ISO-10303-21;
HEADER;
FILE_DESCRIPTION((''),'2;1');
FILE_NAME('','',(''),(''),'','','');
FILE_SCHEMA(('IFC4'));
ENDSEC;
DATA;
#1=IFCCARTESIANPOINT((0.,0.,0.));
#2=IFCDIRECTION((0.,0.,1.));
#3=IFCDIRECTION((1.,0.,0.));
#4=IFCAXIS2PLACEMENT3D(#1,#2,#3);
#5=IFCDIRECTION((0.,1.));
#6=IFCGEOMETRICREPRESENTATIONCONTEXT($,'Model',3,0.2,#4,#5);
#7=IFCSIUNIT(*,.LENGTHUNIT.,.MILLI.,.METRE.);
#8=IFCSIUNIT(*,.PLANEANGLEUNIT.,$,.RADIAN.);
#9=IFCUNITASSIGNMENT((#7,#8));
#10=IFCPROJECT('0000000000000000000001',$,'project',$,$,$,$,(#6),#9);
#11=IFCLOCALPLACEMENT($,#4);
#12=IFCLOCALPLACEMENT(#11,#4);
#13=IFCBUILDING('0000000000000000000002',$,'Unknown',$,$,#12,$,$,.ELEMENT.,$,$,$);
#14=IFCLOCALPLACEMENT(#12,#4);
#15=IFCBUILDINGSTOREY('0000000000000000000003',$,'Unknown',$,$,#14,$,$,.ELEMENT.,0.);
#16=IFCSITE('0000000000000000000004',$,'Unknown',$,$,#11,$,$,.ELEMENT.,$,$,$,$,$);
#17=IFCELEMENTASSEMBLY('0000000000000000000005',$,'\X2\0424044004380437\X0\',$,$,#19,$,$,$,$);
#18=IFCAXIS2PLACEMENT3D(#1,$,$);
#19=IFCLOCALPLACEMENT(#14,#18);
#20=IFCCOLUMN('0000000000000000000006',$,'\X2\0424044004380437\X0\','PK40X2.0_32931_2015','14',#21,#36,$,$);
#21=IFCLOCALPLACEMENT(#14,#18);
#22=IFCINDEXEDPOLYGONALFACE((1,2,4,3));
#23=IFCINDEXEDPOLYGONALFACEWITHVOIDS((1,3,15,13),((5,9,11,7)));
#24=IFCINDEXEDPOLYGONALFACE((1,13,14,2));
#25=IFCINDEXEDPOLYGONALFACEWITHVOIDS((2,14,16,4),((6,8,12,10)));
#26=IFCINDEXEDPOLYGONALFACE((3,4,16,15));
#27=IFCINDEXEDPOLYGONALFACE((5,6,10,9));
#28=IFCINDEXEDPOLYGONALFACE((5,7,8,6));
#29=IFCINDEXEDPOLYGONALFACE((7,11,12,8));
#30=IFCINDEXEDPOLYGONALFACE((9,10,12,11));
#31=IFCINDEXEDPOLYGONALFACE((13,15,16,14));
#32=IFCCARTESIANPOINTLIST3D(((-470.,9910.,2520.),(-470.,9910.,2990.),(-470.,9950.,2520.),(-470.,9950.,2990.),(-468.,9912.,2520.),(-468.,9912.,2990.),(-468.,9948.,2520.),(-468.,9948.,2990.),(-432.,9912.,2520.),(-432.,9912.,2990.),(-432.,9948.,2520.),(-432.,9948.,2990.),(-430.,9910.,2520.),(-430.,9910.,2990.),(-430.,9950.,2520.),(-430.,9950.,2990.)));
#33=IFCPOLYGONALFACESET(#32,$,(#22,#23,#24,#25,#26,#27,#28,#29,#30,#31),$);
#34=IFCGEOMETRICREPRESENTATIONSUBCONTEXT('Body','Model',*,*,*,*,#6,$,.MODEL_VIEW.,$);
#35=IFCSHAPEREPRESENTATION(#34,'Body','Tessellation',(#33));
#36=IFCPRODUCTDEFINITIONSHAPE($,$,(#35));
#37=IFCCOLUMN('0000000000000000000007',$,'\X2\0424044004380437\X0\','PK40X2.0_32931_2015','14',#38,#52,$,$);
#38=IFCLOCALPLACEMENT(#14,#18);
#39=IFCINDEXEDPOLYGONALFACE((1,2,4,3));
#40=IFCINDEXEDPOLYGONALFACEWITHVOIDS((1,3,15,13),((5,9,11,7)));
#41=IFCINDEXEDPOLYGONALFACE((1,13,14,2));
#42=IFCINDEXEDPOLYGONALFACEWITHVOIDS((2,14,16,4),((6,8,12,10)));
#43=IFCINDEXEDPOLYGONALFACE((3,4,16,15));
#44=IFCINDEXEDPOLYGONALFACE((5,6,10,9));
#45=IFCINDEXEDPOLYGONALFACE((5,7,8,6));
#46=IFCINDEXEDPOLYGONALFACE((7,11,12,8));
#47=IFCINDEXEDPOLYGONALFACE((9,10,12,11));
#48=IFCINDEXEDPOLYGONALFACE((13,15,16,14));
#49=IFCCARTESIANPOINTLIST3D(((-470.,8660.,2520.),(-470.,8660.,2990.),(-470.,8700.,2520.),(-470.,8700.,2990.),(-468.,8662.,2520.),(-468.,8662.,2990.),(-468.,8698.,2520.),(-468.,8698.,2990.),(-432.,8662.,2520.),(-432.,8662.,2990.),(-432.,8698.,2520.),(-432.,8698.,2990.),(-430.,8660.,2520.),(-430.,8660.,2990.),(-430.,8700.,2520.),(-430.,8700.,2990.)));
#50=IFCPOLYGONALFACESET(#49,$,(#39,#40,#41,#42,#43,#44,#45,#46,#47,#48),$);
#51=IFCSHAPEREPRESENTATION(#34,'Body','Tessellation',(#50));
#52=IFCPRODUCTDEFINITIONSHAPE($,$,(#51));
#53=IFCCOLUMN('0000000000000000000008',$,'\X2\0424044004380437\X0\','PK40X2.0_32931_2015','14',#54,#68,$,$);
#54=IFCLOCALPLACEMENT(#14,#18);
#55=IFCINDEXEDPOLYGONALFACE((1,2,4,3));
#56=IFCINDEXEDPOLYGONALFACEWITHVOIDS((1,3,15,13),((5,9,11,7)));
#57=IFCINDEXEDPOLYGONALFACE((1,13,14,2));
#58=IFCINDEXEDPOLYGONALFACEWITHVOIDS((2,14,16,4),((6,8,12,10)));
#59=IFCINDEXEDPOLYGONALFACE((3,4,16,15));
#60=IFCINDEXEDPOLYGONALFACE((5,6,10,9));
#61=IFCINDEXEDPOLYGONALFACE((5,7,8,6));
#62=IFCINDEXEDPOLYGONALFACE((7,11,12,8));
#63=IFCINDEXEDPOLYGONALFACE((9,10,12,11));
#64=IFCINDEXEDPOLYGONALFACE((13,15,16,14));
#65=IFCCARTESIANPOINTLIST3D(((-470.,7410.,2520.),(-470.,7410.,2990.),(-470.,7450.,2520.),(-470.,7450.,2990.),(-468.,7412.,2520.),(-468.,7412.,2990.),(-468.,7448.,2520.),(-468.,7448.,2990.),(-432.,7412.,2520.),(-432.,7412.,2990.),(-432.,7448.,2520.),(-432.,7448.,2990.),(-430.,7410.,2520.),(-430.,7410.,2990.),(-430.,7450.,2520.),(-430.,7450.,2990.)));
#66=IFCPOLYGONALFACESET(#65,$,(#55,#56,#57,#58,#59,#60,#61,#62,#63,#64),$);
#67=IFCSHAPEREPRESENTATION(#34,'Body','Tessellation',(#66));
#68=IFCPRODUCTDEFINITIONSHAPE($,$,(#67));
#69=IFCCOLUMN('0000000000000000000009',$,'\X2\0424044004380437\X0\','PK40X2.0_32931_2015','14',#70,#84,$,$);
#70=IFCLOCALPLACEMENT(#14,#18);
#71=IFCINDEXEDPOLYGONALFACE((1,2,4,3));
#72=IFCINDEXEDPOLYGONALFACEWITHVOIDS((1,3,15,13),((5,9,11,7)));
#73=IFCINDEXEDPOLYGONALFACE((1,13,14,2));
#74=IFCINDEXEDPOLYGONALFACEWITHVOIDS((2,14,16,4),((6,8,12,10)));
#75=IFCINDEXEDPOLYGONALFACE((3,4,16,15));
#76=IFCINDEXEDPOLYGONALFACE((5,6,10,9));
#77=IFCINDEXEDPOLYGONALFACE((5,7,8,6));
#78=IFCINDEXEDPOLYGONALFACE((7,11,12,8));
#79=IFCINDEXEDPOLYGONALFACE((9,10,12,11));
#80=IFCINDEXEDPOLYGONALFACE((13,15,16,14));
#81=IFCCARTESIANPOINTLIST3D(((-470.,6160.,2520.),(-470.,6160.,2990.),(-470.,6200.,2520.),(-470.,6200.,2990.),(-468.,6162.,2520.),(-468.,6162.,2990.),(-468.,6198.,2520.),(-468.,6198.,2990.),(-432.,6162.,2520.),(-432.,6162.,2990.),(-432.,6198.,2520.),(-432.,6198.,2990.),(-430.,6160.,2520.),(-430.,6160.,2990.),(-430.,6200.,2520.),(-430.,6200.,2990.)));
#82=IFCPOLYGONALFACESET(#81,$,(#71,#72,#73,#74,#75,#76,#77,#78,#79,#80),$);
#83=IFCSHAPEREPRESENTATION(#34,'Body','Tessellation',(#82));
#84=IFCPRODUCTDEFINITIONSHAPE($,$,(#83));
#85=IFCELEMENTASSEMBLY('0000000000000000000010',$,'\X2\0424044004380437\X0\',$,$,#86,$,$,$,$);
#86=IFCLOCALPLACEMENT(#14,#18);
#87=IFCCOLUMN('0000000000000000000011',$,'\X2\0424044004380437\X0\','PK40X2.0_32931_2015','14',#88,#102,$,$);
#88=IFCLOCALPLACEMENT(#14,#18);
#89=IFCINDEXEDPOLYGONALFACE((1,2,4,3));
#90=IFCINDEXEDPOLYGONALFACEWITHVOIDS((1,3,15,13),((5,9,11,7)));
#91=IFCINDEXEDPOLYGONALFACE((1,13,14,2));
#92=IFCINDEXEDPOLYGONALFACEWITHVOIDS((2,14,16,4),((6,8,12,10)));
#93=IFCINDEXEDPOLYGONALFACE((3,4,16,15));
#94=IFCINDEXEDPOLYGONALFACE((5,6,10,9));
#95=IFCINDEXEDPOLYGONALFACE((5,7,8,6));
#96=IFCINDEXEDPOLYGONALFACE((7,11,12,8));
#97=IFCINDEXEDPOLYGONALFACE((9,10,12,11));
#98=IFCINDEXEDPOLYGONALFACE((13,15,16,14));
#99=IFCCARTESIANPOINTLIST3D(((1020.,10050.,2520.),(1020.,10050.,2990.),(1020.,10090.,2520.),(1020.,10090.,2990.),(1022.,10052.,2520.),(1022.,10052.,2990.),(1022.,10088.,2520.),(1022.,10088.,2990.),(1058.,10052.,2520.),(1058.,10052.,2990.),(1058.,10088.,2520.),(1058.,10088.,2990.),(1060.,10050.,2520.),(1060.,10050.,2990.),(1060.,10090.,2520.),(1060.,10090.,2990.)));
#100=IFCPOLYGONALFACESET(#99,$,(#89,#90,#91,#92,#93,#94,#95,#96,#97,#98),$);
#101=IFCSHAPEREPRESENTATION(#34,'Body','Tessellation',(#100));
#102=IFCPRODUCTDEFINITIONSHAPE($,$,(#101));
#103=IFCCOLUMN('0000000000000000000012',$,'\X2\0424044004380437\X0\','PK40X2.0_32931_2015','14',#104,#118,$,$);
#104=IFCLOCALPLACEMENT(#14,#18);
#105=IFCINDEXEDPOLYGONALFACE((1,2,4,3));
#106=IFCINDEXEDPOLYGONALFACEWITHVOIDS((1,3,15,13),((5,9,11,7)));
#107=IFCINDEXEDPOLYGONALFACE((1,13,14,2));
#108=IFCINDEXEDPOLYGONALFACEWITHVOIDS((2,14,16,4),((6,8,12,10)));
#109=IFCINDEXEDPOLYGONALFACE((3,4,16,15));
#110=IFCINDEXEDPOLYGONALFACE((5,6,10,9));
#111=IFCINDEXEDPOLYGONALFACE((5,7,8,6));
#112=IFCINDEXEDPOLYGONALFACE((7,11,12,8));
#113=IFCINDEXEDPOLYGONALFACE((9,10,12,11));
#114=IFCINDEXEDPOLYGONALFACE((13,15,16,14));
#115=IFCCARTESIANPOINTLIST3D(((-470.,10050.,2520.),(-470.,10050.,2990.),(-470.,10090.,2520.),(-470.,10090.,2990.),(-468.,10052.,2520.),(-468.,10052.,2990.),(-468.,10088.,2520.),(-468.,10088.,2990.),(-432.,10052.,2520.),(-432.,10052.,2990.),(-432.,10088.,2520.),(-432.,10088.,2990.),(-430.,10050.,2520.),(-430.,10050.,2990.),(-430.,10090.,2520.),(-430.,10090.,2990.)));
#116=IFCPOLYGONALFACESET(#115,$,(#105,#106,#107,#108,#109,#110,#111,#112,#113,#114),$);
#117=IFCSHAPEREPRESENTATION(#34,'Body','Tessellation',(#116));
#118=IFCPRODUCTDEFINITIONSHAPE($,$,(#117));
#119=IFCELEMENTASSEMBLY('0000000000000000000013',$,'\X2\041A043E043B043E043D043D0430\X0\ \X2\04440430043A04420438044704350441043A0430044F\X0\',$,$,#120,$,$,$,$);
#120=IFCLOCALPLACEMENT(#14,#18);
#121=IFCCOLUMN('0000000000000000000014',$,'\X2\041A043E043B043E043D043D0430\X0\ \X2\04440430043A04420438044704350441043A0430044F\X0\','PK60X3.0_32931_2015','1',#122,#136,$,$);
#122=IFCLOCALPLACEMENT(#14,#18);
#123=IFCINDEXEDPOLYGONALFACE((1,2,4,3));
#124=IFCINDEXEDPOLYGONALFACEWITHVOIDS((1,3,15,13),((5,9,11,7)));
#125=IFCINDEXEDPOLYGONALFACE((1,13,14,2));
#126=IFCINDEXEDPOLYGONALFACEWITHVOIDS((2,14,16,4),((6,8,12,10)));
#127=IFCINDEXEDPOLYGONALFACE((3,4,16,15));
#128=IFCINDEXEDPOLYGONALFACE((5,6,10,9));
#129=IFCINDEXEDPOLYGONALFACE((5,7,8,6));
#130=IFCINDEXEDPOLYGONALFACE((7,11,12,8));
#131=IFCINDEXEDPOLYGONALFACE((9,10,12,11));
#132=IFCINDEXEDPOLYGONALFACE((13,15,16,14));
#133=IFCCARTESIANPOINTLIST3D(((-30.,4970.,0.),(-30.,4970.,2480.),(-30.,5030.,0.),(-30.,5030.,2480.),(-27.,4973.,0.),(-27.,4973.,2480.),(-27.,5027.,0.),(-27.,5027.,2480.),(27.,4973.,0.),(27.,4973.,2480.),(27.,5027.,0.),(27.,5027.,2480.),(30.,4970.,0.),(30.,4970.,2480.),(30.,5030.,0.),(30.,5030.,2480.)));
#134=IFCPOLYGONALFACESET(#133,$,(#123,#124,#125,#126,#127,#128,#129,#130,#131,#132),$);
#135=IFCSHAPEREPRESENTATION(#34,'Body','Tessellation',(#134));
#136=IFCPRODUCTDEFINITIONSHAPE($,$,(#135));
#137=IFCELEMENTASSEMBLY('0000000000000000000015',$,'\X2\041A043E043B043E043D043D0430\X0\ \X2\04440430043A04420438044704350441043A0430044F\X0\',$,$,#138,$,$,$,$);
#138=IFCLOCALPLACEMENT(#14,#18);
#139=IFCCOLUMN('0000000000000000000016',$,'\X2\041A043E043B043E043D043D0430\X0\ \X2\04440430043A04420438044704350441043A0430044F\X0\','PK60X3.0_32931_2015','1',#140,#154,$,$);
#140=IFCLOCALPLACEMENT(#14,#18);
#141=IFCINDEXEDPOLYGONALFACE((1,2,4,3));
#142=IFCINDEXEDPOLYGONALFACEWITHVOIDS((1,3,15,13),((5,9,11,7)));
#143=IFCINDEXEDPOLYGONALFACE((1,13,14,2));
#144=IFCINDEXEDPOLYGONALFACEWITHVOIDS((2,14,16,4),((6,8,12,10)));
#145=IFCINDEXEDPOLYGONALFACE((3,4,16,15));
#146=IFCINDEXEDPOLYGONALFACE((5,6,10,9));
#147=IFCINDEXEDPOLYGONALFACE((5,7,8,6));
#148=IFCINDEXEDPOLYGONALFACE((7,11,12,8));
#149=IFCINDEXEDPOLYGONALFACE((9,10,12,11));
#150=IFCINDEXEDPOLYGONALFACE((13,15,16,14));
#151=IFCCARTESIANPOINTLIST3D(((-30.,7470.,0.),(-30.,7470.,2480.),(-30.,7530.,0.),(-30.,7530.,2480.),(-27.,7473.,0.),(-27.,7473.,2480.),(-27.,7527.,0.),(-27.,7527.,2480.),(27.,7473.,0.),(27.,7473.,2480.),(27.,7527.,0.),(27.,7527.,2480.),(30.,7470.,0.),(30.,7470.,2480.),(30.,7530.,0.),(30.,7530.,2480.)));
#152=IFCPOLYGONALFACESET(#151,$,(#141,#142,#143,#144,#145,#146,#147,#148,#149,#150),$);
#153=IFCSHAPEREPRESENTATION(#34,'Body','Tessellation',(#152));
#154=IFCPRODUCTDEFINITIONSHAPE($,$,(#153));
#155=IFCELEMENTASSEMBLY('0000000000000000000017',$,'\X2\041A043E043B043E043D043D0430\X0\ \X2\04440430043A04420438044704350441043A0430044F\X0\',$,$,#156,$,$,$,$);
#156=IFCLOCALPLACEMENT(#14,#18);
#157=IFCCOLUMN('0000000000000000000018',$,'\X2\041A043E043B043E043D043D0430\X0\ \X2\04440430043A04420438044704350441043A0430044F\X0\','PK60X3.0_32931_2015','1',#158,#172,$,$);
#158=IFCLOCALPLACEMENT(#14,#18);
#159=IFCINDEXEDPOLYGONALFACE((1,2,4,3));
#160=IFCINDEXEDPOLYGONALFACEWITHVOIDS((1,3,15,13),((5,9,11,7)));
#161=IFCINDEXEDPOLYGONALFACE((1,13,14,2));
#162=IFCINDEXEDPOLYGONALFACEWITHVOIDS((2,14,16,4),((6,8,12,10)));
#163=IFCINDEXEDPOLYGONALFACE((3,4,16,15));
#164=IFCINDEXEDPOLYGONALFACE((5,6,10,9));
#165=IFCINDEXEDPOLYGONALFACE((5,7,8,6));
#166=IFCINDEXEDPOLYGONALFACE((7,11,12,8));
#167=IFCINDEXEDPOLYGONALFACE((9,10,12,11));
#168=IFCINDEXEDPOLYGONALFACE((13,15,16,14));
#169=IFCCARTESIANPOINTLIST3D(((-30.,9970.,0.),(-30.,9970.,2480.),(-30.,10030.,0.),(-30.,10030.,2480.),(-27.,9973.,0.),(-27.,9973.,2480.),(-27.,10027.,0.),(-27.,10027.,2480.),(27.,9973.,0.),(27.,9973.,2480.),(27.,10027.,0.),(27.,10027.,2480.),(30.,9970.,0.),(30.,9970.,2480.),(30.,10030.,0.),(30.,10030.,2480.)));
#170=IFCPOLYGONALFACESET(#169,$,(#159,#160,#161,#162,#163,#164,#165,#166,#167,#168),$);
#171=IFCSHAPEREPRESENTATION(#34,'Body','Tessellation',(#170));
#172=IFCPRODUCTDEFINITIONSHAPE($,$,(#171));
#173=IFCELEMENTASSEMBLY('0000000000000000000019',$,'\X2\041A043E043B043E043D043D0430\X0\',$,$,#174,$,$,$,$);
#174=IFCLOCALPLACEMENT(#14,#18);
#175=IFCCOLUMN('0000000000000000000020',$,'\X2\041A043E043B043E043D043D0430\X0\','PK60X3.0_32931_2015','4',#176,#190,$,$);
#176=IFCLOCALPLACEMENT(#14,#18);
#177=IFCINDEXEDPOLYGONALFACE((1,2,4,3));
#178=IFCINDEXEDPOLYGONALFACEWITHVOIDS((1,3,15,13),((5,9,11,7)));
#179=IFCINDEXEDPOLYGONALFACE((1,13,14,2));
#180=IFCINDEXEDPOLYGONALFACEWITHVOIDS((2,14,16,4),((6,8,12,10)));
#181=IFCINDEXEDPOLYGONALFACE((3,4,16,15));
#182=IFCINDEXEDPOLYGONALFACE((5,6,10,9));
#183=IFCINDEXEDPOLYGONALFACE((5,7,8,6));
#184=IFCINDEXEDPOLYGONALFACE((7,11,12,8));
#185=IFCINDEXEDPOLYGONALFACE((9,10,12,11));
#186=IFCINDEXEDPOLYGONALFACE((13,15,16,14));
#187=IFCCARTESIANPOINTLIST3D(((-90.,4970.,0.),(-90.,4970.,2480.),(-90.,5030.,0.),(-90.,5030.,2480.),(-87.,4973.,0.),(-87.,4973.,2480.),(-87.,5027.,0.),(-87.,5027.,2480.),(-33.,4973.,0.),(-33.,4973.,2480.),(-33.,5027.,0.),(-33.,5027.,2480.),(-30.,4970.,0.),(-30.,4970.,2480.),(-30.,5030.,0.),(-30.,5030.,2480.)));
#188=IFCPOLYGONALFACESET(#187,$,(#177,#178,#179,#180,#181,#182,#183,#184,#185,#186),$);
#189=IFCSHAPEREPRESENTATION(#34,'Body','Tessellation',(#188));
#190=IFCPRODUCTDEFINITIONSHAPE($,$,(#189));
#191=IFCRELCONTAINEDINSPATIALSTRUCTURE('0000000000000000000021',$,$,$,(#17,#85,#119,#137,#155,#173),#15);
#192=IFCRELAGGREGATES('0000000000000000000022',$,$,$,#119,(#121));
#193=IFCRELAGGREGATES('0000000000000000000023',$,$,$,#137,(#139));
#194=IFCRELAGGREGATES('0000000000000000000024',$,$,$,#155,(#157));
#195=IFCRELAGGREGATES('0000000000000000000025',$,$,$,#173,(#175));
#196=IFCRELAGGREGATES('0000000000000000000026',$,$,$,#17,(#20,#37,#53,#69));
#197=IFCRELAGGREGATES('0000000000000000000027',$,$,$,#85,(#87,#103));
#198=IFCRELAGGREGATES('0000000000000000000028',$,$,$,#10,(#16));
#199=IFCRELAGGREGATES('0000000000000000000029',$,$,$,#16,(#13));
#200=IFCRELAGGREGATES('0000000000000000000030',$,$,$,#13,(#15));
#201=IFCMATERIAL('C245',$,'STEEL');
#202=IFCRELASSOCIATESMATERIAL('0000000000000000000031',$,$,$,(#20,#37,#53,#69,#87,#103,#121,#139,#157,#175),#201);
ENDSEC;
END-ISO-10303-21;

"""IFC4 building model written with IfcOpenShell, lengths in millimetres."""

from ifc_helpers import new_model, si_unit, direction, frame, origin_with_axes, place, context, subcontext, project, spatial, line, indexed_curve, outline, extrude, material, element, aggregate, save


model = new_model("IFC4")

# Units and contexts
model_context = context("Model", 3, precision=0.2, world=origin_with_axes(), true_north=direction((0.0, 1.0)))
body_context = subcontext(model_context, "Body", "Model", "MODEL_VIEW")
ifc_project = project(units=[si_unit("LENGTHUNIT", "METRE", prefix="MILLI"), si_unit("PLANEANGLEUNIT", "RADIAN")], contexts=[model_context])

# Site, building, storey
site_placement = place(None, origin_with_axes())
site = spatial("IfcSite", under=ifc_project, at=site_placement, Name="Unknown", CompositionType="ELEMENT")
building_placement = place(site_placement, origin_with_axes())
building = spatial("IfcBuilding", under=site, at=building_placement, Name="Unknown", CompositionType="ELEMENT")
storey_placement = place(building_placement, origin_with_axes())
storey = spatial("IfcBuildingStorey", under=building, at=storey_placement, Name="Unknown", CompositionType="ELEMENT", Elevation=0.0)

# Element assemblies, columns
assembly_1_placement = place(storey_placement, frame((-450.0, -500.0, 3010.0), z_axis=(1.0, 0.0, 0.0), x_axis=(0.0, 1.0, 0.0)))
assembly_1 = element("IfcElementAssembly", 1, at=assembly_1_placement, inside=storey, Name="Фриз")
ifc_material = material(Name="C245", Category="STEEL")
column_1_placement = place(assembly_1_placement, frame((10430.0, -490.0, 0.0), z_axis=(1.0, 0.0, 0.0), x_axis=(0.0, 1.0, 0.0)))
column_1 = element("IfcColumn", 2, at=column_1_placement, material=ifc_material, Name="Фриз", Description="PK40X2.0_32931_2015", ObjectType="14", context=body_context, shape_type="SolidModel", body=[
    extrude(outline(indexed_curve([(-20.0, -20.0), (20.0, -20.0), (20.0, 20.0), (-20.0, 20.0)], segments=[line(1, 2, 3, 4, 1)]), holes=[indexed_curve([(-18.0, -18.0), (-18.0, 18.0), (18.0, 18.0), (18.0, -18.0)], segments=[line(1, 2, 3, 4, 1)])]), frame((0.0, 0.0, 0.0), z_axis=(-1.0, 0.0, 0.0), x_axis=(0.0, 0.0, 1.0)), (0.0, 0.0, -1.0), 470.0),
])
column_2_placement = place(assembly_1_placement, frame((9180.0, -490.0, 0.0), z_axis=(1.0, 0.0, 0.0), x_axis=(0.0, 1.0, 0.0)))
column_2 = element("IfcColumn", 3, at=column_2_placement, material=ifc_material, Name="Фриз", Description="PK40X2.0_32931_2015", ObjectType="14", context=body_context, shape_type="SolidModel", body=[
    extrude(outline(indexed_curve([(-20.0, -20.0), (20.0, -20.0), (20.0, 20.0), (-20.0, 20.0)], segments=[line(1, 2, 3, 4, 1)]), holes=[indexed_curve([(-18.0, -18.0), (-18.0, 18.0), (18.0, 18.0), (18.0, -18.0)], segments=[line(1, 2, 3, 4, 1)])]), frame((0.0, 0.0, 0.0), z_axis=(-1.0, 0.0, 0.0), x_axis=(0.0, 0.0, 1.0)), (0.0, 0.0, -1.0), 470.0),
])
column_3_placement = place(assembly_1_placement, frame((7930.0, -490.0, 0.0), z_axis=(1.0, 0.0, 0.0), x_axis=(0.0, 1.0, 0.0)))
column_3 = element("IfcColumn", 4, at=column_3_placement, material=ifc_material, Name="Фриз", Description="PK40X2.0_32931_2015", ObjectType="14", context=body_context, shape_type="SolidModel", body=[
    extrude(outline(indexed_curve([(-20.0, -20.0), (20.0, -20.0), (20.0, 20.0), (-20.0, 20.0)], segments=[line(1, 2, 3, 4, 1)]), holes=[indexed_curve([(-18.0, -18.0), (-18.0, 18.0), (18.0, 18.0), (18.0, -18.0)], segments=[line(1, 2, 3, 4, 1)])]), frame((0.0, 0.0, 0.0), z_axis=(-1.0, 0.0, 0.0), x_axis=(0.0, 0.0, 1.0)), (0.0, 0.0, -1.0), 470.0),
])
column_4_placement = place(assembly_1_placement, frame((6680.0, -490.0, 0.0), z_axis=(1.0, 0.0, 0.0), x_axis=(0.0, 1.0, 0.0)))
column_4 = element("IfcColumn", 5, at=column_4_placement, material=ifc_material, Name="Фриз", Description="PK40X2.0_32931_2015", ObjectType="14", context=body_context, shape_type="SolidModel", body=[
    extrude(outline(indexed_curve([(-20.0, -20.0), (20.0, -20.0), (20.0, 20.0), (-20.0, 20.0)], segments=[line(1, 2, 3, 4, 1)]), holes=[indexed_curve([(-18.0, -18.0), (-18.0, 18.0), (18.0, 18.0), (18.0, -18.0)], segments=[line(1, 2, 3, 4, 1)])]), frame((0.0, 0.0, 0.0), z_axis=(-1.0, 0.0, 0.0), x_axis=(0.0, 0.0, 1.0)), (0.0, 0.0, -1.0), 470.0),
])
assembly_2_placement = place(storey_placement, frame((-470.0, 10070.0, 3010.0), z_axis=(0.0, -1.0, 0.0), x_axis=(1.0, 0.0, 0.0)))
assembly_2 = element("IfcElementAssembly", 6, at=assembly_2_placement, inside=storey, Name="Фриз")
column_5_placement = place(assembly_2_placement, frame((1510.0, -490.0, 0.0), z_axis=(0.0, 0.0, -1.0), x_axis=(0.0, 1.0, 0.0)))
column_5 = element("IfcColumn", 7, at=column_5_placement, material=ifc_material, Name="Фриз", Description="PK40X2.0_32931_2015", ObjectType="14", context=body_context, shape_type="SolidModel", body=[
    extrude(outline(indexed_curve([(-20.0, -20.0), (20.0, -20.0), (20.0, 20.0), (-20.0, 20.0)], segments=[line(1, 2, 3, 4, 1)]), holes=[indexed_curve([(-18.0, -18.0), (-18.0, 18.0), (18.0, 18.0), (18.0, -18.0)], segments=[line(1, 2, 3, 4, 1)])]), frame((0.0, 0.0, 0.0), z_axis=(-1.0, 0.0, 0.0), x_axis=(0.0, 0.0, 1.0)), (0.0, 0.0, -1.0), 470.0),
])
column_6_placement = place(assembly_2_placement, frame((20.0, -490.0, 0.0), z_axis=(0.0, 0.0, -1.0), x_axis=(0.0, 1.0, 0.0)))
column_6 = element("IfcColumn", 8, at=column_6_placement, material=ifc_material, Name="Фриз", Description="PK40X2.0_32931_2015", ObjectType="14", context=body_context, shape_type="SolidModel", body=[
    extrude(outline(indexed_curve([(-20.0, -20.0), (20.0, -20.0), (20.0, 20.0), (-20.0, 20.0)], segments=[line(1, 2, 3, 4, 1)]), holes=[indexed_curve([(-18.0, -18.0), (-18.0, 18.0), (18.0, 18.0), (18.0, -18.0)], segments=[line(1, 2, 3, 4, 1)])]), frame((0.0, 0.0, 0.0), z_axis=(-1.0, 0.0, 0.0), x_axis=(0.0, 0.0, 1.0)), (0.0, 0.0, -1.0), 470.0),
])

# Element assemblies, columns
assembly_3_placement = place(storey_placement, frame((0.0, 5000.0, 0.0), z_axis=(-1.0, 0.0, 0.0), x_axis=(0.0, 0.0, 1.0)))
assembly_3 = element("IfcElementAssembly", 9, at=assembly_3_placement, inside=storey, Name="Колонна фактическая")
column_7_placement = place(assembly_3_placement, origin_with_axes())
column_7 = element("IfcColumn", 10, at=column_7_placement, material=ifc_material, Name="Колонна фактическая", Description="PK60X3.0_32931_2015", ObjectType="1", context=body_context, shape_type="SolidModel", body=[
    extrude(outline(indexed_curve([(-30.0, -30.0), (30.0, -30.0), (30.0, 30.0), (-30.0, 30.0)], segments=[line(1, 2, 3, 4, 1)]), holes=[indexed_curve([(-27.0, -27.0), (-27.0, 27.0), (27.0, 27.0), (27.0, -27.0)], segments=[line(1, 2, 3, 4, 1)])]), frame((0.0, 0.0, 0.0), z_axis=(-1.0, 0.0, 0.0), x_axis=(0.0, 0.0, 1.0)), (0.0, 0.0, -1.0), 2480.0),
])
aggregate(assembly_3, [column_7])
assembly_4_placement = place(storey_placement, frame((0.0, 7500.0, 0.0), z_axis=(-1.0, 0.0, 0.0), x_axis=(0.0, 0.0, 1.0)))
assembly_4 = element("IfcElementAssembly", 11, at=assembly_4_placement, inside=storey, Name="Колонна фактическая")
column_8_placement = place(assembly_4_placement, origin_with_axes())
column_8 = element("IfcColumn", 12, at=column_8_placement, material=ifc_material, Name="Колонна фактическая", Description="PK60X3.0_32931_2015", ObjectType="1", context=body_context, shape_type="SolidModel", body=[
    extrude(outline(indexed_curve([(-30.0, -30.0), (30.0, -30.0), (30.0, 30.0), (-30.0, 30.0)], segments=[line(1, 2, 3, 4, 1)]), holes=[indexed_curve([(-27.0, -27.0), (-27.0, 27.0), (27.0, 27.0), (27.0, -27.0)], segments=[line(1, 2, 3, 4, 1)])]), frame((0.0, 0.0, 0.0), z_axis=(-1.0, 0.0, 0.0), x_axis=(0.0, 0.0, 1.0)), (0.0, 0.0, -1.0), 2480.0),
])
aggregate(assembly_4, [column_8])
assembly_5_placement = place(storey_placement, frame((0.0, 10000.0, 0.0), z_axis=(-1.0, 0.0, 0.0), x_axis=(0.0, 0.0, 1.0)))
assembly_5 = element("IfcElementAssembly", 13, at=assembly_5_placement, inside=storey, Name="Колонна фактическая")
column_9_placement = place(assembly_5_placement, origin_with_axes())
column_9 = element("IfcColumn", 14, at=column_9_placement, material=ifc_material, Name="Колонна фактическая", Description="PK60X3.0_32931_2015", ObjectType="1", context=body_context, shape_type="SolidModel", body=[
    extrude(outline(indexed_curve([(-30.0, -30.0), (30.0, -30.0), (30.0, 30.0), (-30.0, 30.0)], segments=[line(1, 2, 3, 4, 1)]), holes=[indexed_curve([(-27.0, -27.0), (-27.0, 27.0), (27.0, 27.0), (27.0, -27.0)], segments=[line(1, 2, 3, 4, 1)])]), frame((0.0, 0.0, 0.0), z_axis=(-1.0, 0.0, 0.0), x_axis=(0.0, 0.0, 1.0)), (0.0, 0.0, -1.0), 2480.0),
])
aggregate(assembly_5, [column_9])
assembly_6_placement = place(storey_placement, frame((-60.0, 5000.0, 0.0), z_axis=(-1.0, 0.0, 0.0), x_axis=(0.0, 0.0, 1.0)))
assembly_6 = element("IfcElementAssembly", 15, at=assembly_6_placement, inside=storey, Name="Колонна")
column_10_placement = place(assembly_6_placement, origin_with_axes())
column_10 = element("IfcColumn", 16, at=column_10_placement, material=ifc_material, Name="Колонна", Description="PK60X3.0_32931_2015", ObjectType="4", context=body_context, shape_type="SolidModel", body=[
    extrude(outline(indexed_curve([(-30.0, -30.0), (30.0, -30.0), (30.0, 30.0), (-30.0, 30.0)], segments=[line(1, 2, 3, 4, 1)]), holes=[indexed_curve([(-27.0, -27.0), (-27.0, 27.0), (27.0, 27.0), (27.0, -27.0)], segments=[line(1, 2, 3, 4, 1)])]), frame((0.0, 0.0, 0.0), z_axis=(-1.0, 0.0, 0.0), x_axis=(0.0, 0.0, 1.0)), (0.0, 0.0, -1.0), 2480.0),
])
aggregate(assembly_6, [column_10])

aggregate(assembly_1, [column_1, column_2, column_3, column_4])
aggregate(assembly_2, [column_5, column_6])

save(model, "model.ifc")
